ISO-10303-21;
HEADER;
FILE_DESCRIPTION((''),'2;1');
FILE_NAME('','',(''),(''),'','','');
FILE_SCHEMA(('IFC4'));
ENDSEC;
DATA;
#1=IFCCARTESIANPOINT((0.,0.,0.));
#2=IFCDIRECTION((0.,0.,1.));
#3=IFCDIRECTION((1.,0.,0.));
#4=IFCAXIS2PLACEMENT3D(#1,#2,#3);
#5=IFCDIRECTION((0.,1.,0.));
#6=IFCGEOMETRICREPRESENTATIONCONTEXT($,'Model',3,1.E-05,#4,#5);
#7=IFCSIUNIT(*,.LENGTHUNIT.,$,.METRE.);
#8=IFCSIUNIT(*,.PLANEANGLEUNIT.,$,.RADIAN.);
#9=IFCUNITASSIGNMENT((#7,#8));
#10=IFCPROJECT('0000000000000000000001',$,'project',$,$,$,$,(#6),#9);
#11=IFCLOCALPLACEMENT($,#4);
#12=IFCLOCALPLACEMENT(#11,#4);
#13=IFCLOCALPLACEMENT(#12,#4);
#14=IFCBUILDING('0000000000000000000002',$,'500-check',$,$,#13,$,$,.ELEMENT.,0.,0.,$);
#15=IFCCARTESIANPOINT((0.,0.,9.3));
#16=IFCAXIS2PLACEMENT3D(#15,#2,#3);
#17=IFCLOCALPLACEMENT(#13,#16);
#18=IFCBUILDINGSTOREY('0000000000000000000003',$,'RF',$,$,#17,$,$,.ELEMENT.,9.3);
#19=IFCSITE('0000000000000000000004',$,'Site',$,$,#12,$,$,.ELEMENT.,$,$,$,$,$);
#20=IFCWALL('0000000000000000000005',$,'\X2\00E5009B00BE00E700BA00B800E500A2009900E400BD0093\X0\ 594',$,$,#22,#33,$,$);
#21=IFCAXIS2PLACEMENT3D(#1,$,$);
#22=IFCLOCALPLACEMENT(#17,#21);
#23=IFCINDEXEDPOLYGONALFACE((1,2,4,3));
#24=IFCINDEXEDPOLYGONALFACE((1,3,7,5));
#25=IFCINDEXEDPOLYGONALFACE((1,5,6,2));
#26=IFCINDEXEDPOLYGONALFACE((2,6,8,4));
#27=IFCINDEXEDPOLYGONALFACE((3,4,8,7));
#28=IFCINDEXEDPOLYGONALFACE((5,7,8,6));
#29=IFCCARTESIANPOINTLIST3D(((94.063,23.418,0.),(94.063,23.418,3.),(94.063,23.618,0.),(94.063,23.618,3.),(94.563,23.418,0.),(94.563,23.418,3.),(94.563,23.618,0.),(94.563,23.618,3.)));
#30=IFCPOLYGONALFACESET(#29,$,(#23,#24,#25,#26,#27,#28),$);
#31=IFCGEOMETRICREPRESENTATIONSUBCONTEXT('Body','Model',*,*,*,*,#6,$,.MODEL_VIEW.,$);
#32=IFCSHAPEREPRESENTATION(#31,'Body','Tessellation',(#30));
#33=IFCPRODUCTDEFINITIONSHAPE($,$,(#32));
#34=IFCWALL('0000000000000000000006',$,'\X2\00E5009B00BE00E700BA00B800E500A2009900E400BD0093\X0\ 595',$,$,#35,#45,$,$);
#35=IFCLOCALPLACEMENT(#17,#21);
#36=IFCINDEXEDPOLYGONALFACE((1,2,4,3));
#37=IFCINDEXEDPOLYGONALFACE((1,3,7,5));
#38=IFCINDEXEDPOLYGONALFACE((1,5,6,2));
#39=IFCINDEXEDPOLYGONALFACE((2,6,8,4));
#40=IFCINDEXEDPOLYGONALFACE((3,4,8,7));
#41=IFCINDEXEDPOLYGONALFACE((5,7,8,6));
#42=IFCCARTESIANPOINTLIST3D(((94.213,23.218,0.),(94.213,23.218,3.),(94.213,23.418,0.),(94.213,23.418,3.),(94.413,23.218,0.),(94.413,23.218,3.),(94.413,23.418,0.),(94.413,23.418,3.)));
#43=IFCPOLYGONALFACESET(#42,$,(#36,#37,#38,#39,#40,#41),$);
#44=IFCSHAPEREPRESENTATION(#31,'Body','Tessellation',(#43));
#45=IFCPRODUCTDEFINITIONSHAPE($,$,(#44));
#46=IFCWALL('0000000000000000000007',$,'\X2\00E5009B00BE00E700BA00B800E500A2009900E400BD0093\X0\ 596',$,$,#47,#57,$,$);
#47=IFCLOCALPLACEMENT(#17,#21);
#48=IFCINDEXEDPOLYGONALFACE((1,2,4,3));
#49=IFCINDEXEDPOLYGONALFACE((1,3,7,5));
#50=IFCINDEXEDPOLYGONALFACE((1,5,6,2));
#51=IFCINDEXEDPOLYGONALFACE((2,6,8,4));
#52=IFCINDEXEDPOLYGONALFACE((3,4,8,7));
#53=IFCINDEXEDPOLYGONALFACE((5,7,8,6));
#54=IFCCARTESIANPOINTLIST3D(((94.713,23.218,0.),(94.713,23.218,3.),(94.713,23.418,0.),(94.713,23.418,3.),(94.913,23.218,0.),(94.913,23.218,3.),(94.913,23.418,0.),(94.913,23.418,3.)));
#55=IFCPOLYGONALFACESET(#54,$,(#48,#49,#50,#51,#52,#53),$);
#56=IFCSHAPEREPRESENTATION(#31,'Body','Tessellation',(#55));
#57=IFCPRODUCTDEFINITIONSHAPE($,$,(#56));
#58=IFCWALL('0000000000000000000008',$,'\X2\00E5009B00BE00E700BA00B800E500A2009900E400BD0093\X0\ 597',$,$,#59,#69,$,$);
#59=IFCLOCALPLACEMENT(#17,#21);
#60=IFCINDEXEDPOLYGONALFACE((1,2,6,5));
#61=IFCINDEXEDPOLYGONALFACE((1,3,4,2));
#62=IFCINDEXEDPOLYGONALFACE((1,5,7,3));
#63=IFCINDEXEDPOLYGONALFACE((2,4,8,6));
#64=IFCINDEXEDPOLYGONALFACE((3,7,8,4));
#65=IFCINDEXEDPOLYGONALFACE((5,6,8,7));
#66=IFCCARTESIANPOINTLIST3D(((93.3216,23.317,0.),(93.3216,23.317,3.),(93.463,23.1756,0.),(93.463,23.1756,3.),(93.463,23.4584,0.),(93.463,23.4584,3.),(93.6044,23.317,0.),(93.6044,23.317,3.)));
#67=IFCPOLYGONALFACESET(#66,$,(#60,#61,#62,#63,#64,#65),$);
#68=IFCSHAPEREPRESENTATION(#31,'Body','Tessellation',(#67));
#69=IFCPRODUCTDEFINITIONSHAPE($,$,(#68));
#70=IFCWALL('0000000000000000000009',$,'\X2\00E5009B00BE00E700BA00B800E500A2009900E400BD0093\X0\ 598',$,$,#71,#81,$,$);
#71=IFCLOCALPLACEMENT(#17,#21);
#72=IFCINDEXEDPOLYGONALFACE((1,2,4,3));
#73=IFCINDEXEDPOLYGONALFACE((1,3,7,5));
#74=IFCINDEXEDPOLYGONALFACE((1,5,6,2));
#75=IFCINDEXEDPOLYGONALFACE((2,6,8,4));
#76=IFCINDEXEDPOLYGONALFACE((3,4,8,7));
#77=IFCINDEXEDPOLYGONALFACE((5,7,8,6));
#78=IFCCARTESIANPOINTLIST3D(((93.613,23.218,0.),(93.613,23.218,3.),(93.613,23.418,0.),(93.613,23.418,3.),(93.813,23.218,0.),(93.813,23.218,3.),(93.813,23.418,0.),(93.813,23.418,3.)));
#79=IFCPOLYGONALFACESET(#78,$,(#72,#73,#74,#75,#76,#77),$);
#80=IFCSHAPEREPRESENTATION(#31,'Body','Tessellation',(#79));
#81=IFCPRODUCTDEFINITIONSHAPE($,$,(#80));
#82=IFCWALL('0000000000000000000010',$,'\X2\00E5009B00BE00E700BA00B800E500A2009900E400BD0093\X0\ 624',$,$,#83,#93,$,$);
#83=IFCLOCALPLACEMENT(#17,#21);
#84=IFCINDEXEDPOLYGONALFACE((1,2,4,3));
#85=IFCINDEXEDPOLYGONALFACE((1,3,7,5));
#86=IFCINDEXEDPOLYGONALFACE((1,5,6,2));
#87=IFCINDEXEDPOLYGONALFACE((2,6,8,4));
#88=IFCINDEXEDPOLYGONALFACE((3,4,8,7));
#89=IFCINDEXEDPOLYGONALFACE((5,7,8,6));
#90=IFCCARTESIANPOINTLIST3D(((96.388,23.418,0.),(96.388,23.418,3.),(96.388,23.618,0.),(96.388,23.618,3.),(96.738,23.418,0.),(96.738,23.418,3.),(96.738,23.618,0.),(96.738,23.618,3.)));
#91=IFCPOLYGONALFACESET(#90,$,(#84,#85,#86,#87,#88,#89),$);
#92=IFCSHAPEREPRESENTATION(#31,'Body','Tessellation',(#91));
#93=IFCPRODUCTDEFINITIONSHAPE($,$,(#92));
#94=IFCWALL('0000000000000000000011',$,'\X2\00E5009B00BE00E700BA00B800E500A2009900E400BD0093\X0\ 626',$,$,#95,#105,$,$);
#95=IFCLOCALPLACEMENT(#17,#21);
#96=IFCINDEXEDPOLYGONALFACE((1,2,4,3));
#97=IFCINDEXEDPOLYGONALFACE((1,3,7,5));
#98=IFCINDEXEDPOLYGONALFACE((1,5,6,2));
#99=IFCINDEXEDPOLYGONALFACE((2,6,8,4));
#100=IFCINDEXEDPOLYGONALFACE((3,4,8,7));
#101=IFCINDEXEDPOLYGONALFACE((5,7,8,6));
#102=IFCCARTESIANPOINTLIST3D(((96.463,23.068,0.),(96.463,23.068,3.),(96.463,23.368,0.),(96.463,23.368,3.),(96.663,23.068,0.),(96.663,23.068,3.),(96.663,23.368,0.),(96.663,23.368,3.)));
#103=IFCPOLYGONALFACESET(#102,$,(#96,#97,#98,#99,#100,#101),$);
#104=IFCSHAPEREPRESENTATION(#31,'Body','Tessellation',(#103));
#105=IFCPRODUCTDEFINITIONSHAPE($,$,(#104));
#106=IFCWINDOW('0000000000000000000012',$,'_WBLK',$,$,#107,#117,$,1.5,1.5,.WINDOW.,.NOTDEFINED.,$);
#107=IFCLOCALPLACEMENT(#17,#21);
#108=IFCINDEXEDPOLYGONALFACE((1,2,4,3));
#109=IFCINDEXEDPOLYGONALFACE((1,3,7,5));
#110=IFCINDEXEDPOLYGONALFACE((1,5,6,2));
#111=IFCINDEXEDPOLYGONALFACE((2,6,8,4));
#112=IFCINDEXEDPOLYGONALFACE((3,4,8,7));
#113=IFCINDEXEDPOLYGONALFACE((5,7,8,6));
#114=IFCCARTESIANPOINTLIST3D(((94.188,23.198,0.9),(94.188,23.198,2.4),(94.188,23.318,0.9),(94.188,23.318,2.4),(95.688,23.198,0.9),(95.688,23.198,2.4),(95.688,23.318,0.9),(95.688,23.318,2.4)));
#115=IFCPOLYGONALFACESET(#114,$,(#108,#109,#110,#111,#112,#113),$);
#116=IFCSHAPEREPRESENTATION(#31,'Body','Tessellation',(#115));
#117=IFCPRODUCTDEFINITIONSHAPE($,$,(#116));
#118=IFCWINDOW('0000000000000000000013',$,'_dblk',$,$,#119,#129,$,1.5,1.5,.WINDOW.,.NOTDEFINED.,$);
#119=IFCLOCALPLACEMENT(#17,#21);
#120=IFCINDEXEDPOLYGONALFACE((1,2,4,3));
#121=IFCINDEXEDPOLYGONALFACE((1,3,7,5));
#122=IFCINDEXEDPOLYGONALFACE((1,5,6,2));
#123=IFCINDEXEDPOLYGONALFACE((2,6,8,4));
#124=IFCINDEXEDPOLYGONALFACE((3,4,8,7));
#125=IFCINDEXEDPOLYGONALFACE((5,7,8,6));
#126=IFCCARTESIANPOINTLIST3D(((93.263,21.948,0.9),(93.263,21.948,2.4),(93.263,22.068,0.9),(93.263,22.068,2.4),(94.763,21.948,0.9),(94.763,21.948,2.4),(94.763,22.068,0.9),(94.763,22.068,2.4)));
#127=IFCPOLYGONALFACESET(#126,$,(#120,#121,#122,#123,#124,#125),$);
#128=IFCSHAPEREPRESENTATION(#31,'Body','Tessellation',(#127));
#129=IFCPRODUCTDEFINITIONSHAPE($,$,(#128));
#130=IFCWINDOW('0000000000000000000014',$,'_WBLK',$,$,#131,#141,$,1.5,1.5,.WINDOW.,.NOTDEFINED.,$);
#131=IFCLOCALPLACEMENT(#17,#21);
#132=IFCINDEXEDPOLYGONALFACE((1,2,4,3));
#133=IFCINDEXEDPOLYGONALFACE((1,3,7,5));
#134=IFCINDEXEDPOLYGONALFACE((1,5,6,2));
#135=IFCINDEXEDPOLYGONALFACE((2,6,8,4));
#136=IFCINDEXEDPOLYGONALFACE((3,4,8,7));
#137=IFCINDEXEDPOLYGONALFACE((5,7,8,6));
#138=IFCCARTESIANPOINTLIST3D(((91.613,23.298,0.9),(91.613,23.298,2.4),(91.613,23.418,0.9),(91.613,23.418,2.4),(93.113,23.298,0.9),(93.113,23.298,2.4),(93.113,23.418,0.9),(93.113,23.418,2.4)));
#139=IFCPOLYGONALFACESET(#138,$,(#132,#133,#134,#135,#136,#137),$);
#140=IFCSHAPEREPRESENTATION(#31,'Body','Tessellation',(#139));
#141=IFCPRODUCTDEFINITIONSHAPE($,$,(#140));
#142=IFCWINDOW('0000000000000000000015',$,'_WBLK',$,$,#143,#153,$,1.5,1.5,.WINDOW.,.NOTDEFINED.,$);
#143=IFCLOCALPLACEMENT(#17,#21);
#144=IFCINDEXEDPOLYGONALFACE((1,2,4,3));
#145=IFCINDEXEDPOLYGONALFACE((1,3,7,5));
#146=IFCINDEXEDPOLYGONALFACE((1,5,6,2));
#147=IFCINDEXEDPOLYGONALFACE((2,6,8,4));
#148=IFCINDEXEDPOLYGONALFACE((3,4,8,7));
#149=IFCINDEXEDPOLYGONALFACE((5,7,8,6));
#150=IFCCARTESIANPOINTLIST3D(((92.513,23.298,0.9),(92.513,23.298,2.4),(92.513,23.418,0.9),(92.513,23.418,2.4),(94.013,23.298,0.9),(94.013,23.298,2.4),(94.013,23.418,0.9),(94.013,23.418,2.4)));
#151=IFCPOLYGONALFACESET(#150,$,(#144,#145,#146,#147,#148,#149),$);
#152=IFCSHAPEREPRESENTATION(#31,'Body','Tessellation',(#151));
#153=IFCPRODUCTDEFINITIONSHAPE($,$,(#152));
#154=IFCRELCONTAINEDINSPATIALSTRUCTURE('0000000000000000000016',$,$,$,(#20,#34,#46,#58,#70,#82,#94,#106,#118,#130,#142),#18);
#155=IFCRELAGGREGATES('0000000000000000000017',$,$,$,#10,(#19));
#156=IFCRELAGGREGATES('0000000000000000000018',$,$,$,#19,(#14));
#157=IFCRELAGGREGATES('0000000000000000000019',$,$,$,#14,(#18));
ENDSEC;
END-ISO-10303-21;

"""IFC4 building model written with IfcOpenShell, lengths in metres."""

from ifc_helpers import new_model, si_unit, direction, frame, frame_2d, origin_with_axes, place, context, subcontext, project, spatial, rectangle, extrude, element, save


model = new_model("IFC4")

# Units and contexts
model_context = context("Model", 3, precision=1e-05, world=origin_with_axes(), true_north=direction((0.0, 1.0, 0.0)))
body_context = subcontext(model_context, "Body", "Model", "MODEL_VIEW")
ifc_project = project(units=[si_unit("LENGTHUNIT", "METRE"), si_unit("PLANEANGLEUNIT", "RADIAN")], contexts=[model_context])

# Site, building, storey
placement = place(None, origin_with_axes())
site_placement = place(placement, origin_with_axes())
site = spatial("IfcSite", under=ifc_project, at=site_placement, Name="Site", CompositionType="ELEMENT")
building_placement = place(site_placement, origin_with_axes())
building = spatial("IfcBuilding", under=site, at=building_placement, Name="500-check", CompositionType="ELEMENT", ElevationOfRefHeight=0.0, ElevationOfTerrain=0.0)
storey_placement = place(building_placement, frame((0.0, 0.0, 9.3), z_axis=(0.0, 0.0, 1.0), x_axis=(1.0, 0.0, 0.0)))
storey = spatial("IfcBuildingStorey", under=building, at=storey_placement, Name="RF", CompositionType="ELEMENT", Elevation=9.3)

# Walls
wall_1_placement = place(storey_placement, frame((94.313, 23.518, 0.0), z_axis=(0.0, 0.0, 1.0), x_axis=(1.0, 0.0, 0.0)))
element("IfcWall", 1, at=wall_1_placement, inside=storey, Name="å\u009b¾çº¸å¢\u0099ä½\u0093 594", context=body_context, shape_type="SweptSolid", body=[
    extrude(rectangle(XDim=0.5, YDim=0.2, at=frame_2d((0.0, 0.0), x_axis=(1.0, 0.0, 0.0))), frame((0.0, 0.0, 0.0), z_axis=(0.0, 0.0, 1.0)), (0.0, 0.0, 1.0), 3.0),
])
for number, where, z_axis, x_axis, name in (
    (2, (94.313, 23.318, 0.0), (0.0, 0.0, 1.0), (0.0, 1.0, 0.0), "å\u009b¾çº¸å¢\u0099ä½\u0093 595"),
    (3, (94.813, 23.318, 0.0), (0.0, 0.0, 1.0), (0.0, 1.0, 0.0), "å\u009b¾çº¸å¢\u0099ä½\u0093 596"),
    (4, (93.463, 23.317, 0.0), (0.0, 0.0, 1.0), (-0.707107, 0.707107, 0.0), "å\u009b¾çº¸å¢\u0099ä½\u0093 597"),
    (5, (93.713, 23.318, 0.0), (0.0, 0.0, 1.0), (-1.0, 0.0, 0.0), "å\u009b¾çº¸å¢\u0099ä½\u0093 598"),
):
    element("IfcWall", number, at=place(storey_placement, frame(where, z_axis=z_axis, x_axis=x_axis)), inside=storey, Name=name, context=body_context, shape_type="SweptSolid", body=[
        extrude(rectangle(XDim=0.2, YDim=0.2, at=frame_2d((0.0, 0.0), x_axis=(1.0, 0.0, 0.0))), frame((0.0, 0.0, 0.0), z_axis=(0.0, 0.0, 1.0)), (0.0, 0.0, 1.0), 3.0),
    ])
wall_2_placement = place(storey_placement, frame((96.563, 23.518, 0.0), z_axis=(0.0, 0.0, 1.0), x_axis=(1.0, 0.0, 0.0)))
element("IfcWall", 6, at=wall_2_placement, inside=storey, Name="å\u009b¾çº¸å¢\u0099ä½\u0093 624", context=body_context, shape_type="SweptSolid", body=[
    extrude(rectangle(XDim=0.35, YDim=0.2, at=frame_2d((0.0, 0.0), x_axis=(1.0, 0.0, 0.0))), frame((0.0, 0.0, 0.0), z_axis=(0.0, 0.0, 1.0)), (0.0, 0.0, 1.0), 3.0),
])
wall_3_placement = place(storey_placement, frame((96.563, 23.218, 0.0), z_axis=(0.0, 0.0, 1.0), x_axis=(0.0, 1.0, 0.0)))
element("IfcWall", 7, at=wall_3_placement, inside=storey, Name="å\u009b¾çº¸å¢\u0099ä½\u0093 626", context=body_context, shape_type="SweptSolid", body=[
    extrude(rectangle(XDim=0.3, YDim=0.2, at=frame_2d((0.0, 0.0), x_axis=(1.0, 0.0, 0.0))), frame((0.0, 0.0, 0.0), z_axis=(0.0, 0.0, 1.0)), (0.0, 0.0, 1.0), 3.0),
])

# Windows
for number, where, z_axis, x_axis, name in (
    (8, (94.938, 23.258, 0.9), (0.0, 0.0, 1.0), (1.0, 0.0, 0.0), "_WBLK"),
    (9, (94.013, 22.008, 0.9), (0.0, 0.0, 1.0), (1.0, 0.0, 0.0), "_dblk"),
    (10, (92.363, 23.358, 0.9), (0.0, 0.0, 1.0), (1.0, 0.0, 0.0), "_WBLK"),
    (11, (93.263, 23.358, 0.9), (0.0, 0.0, 1.0), (1.0, 0.0, 0.0), "_WBLK"),
):
    element("IfcWindow", number, at=place(storey_placement, frame(where, z_axis=z_axis, x_axis=x_axis)), inside=storey, Name=name, OverallHeight=1.5, OverallWidth=1.5, PartitioningType="NOTDEFINED", PredefinedType="WINDOW", context=body_context, shape_type="SweptSolid", body=[
        extrude(rectangle(XDim=1.5, YDim=0.12, at=frame_2d((0.0, 0.0), x_axis=(1.0, 0.0, 0.0))), frame((0.0, 0.0, 0.0), z_axis=(0.0, 0.0, 1.0)), (0.0, 0.0, 1.0), 1.5),
    ])

save(model, "model.ifc")
